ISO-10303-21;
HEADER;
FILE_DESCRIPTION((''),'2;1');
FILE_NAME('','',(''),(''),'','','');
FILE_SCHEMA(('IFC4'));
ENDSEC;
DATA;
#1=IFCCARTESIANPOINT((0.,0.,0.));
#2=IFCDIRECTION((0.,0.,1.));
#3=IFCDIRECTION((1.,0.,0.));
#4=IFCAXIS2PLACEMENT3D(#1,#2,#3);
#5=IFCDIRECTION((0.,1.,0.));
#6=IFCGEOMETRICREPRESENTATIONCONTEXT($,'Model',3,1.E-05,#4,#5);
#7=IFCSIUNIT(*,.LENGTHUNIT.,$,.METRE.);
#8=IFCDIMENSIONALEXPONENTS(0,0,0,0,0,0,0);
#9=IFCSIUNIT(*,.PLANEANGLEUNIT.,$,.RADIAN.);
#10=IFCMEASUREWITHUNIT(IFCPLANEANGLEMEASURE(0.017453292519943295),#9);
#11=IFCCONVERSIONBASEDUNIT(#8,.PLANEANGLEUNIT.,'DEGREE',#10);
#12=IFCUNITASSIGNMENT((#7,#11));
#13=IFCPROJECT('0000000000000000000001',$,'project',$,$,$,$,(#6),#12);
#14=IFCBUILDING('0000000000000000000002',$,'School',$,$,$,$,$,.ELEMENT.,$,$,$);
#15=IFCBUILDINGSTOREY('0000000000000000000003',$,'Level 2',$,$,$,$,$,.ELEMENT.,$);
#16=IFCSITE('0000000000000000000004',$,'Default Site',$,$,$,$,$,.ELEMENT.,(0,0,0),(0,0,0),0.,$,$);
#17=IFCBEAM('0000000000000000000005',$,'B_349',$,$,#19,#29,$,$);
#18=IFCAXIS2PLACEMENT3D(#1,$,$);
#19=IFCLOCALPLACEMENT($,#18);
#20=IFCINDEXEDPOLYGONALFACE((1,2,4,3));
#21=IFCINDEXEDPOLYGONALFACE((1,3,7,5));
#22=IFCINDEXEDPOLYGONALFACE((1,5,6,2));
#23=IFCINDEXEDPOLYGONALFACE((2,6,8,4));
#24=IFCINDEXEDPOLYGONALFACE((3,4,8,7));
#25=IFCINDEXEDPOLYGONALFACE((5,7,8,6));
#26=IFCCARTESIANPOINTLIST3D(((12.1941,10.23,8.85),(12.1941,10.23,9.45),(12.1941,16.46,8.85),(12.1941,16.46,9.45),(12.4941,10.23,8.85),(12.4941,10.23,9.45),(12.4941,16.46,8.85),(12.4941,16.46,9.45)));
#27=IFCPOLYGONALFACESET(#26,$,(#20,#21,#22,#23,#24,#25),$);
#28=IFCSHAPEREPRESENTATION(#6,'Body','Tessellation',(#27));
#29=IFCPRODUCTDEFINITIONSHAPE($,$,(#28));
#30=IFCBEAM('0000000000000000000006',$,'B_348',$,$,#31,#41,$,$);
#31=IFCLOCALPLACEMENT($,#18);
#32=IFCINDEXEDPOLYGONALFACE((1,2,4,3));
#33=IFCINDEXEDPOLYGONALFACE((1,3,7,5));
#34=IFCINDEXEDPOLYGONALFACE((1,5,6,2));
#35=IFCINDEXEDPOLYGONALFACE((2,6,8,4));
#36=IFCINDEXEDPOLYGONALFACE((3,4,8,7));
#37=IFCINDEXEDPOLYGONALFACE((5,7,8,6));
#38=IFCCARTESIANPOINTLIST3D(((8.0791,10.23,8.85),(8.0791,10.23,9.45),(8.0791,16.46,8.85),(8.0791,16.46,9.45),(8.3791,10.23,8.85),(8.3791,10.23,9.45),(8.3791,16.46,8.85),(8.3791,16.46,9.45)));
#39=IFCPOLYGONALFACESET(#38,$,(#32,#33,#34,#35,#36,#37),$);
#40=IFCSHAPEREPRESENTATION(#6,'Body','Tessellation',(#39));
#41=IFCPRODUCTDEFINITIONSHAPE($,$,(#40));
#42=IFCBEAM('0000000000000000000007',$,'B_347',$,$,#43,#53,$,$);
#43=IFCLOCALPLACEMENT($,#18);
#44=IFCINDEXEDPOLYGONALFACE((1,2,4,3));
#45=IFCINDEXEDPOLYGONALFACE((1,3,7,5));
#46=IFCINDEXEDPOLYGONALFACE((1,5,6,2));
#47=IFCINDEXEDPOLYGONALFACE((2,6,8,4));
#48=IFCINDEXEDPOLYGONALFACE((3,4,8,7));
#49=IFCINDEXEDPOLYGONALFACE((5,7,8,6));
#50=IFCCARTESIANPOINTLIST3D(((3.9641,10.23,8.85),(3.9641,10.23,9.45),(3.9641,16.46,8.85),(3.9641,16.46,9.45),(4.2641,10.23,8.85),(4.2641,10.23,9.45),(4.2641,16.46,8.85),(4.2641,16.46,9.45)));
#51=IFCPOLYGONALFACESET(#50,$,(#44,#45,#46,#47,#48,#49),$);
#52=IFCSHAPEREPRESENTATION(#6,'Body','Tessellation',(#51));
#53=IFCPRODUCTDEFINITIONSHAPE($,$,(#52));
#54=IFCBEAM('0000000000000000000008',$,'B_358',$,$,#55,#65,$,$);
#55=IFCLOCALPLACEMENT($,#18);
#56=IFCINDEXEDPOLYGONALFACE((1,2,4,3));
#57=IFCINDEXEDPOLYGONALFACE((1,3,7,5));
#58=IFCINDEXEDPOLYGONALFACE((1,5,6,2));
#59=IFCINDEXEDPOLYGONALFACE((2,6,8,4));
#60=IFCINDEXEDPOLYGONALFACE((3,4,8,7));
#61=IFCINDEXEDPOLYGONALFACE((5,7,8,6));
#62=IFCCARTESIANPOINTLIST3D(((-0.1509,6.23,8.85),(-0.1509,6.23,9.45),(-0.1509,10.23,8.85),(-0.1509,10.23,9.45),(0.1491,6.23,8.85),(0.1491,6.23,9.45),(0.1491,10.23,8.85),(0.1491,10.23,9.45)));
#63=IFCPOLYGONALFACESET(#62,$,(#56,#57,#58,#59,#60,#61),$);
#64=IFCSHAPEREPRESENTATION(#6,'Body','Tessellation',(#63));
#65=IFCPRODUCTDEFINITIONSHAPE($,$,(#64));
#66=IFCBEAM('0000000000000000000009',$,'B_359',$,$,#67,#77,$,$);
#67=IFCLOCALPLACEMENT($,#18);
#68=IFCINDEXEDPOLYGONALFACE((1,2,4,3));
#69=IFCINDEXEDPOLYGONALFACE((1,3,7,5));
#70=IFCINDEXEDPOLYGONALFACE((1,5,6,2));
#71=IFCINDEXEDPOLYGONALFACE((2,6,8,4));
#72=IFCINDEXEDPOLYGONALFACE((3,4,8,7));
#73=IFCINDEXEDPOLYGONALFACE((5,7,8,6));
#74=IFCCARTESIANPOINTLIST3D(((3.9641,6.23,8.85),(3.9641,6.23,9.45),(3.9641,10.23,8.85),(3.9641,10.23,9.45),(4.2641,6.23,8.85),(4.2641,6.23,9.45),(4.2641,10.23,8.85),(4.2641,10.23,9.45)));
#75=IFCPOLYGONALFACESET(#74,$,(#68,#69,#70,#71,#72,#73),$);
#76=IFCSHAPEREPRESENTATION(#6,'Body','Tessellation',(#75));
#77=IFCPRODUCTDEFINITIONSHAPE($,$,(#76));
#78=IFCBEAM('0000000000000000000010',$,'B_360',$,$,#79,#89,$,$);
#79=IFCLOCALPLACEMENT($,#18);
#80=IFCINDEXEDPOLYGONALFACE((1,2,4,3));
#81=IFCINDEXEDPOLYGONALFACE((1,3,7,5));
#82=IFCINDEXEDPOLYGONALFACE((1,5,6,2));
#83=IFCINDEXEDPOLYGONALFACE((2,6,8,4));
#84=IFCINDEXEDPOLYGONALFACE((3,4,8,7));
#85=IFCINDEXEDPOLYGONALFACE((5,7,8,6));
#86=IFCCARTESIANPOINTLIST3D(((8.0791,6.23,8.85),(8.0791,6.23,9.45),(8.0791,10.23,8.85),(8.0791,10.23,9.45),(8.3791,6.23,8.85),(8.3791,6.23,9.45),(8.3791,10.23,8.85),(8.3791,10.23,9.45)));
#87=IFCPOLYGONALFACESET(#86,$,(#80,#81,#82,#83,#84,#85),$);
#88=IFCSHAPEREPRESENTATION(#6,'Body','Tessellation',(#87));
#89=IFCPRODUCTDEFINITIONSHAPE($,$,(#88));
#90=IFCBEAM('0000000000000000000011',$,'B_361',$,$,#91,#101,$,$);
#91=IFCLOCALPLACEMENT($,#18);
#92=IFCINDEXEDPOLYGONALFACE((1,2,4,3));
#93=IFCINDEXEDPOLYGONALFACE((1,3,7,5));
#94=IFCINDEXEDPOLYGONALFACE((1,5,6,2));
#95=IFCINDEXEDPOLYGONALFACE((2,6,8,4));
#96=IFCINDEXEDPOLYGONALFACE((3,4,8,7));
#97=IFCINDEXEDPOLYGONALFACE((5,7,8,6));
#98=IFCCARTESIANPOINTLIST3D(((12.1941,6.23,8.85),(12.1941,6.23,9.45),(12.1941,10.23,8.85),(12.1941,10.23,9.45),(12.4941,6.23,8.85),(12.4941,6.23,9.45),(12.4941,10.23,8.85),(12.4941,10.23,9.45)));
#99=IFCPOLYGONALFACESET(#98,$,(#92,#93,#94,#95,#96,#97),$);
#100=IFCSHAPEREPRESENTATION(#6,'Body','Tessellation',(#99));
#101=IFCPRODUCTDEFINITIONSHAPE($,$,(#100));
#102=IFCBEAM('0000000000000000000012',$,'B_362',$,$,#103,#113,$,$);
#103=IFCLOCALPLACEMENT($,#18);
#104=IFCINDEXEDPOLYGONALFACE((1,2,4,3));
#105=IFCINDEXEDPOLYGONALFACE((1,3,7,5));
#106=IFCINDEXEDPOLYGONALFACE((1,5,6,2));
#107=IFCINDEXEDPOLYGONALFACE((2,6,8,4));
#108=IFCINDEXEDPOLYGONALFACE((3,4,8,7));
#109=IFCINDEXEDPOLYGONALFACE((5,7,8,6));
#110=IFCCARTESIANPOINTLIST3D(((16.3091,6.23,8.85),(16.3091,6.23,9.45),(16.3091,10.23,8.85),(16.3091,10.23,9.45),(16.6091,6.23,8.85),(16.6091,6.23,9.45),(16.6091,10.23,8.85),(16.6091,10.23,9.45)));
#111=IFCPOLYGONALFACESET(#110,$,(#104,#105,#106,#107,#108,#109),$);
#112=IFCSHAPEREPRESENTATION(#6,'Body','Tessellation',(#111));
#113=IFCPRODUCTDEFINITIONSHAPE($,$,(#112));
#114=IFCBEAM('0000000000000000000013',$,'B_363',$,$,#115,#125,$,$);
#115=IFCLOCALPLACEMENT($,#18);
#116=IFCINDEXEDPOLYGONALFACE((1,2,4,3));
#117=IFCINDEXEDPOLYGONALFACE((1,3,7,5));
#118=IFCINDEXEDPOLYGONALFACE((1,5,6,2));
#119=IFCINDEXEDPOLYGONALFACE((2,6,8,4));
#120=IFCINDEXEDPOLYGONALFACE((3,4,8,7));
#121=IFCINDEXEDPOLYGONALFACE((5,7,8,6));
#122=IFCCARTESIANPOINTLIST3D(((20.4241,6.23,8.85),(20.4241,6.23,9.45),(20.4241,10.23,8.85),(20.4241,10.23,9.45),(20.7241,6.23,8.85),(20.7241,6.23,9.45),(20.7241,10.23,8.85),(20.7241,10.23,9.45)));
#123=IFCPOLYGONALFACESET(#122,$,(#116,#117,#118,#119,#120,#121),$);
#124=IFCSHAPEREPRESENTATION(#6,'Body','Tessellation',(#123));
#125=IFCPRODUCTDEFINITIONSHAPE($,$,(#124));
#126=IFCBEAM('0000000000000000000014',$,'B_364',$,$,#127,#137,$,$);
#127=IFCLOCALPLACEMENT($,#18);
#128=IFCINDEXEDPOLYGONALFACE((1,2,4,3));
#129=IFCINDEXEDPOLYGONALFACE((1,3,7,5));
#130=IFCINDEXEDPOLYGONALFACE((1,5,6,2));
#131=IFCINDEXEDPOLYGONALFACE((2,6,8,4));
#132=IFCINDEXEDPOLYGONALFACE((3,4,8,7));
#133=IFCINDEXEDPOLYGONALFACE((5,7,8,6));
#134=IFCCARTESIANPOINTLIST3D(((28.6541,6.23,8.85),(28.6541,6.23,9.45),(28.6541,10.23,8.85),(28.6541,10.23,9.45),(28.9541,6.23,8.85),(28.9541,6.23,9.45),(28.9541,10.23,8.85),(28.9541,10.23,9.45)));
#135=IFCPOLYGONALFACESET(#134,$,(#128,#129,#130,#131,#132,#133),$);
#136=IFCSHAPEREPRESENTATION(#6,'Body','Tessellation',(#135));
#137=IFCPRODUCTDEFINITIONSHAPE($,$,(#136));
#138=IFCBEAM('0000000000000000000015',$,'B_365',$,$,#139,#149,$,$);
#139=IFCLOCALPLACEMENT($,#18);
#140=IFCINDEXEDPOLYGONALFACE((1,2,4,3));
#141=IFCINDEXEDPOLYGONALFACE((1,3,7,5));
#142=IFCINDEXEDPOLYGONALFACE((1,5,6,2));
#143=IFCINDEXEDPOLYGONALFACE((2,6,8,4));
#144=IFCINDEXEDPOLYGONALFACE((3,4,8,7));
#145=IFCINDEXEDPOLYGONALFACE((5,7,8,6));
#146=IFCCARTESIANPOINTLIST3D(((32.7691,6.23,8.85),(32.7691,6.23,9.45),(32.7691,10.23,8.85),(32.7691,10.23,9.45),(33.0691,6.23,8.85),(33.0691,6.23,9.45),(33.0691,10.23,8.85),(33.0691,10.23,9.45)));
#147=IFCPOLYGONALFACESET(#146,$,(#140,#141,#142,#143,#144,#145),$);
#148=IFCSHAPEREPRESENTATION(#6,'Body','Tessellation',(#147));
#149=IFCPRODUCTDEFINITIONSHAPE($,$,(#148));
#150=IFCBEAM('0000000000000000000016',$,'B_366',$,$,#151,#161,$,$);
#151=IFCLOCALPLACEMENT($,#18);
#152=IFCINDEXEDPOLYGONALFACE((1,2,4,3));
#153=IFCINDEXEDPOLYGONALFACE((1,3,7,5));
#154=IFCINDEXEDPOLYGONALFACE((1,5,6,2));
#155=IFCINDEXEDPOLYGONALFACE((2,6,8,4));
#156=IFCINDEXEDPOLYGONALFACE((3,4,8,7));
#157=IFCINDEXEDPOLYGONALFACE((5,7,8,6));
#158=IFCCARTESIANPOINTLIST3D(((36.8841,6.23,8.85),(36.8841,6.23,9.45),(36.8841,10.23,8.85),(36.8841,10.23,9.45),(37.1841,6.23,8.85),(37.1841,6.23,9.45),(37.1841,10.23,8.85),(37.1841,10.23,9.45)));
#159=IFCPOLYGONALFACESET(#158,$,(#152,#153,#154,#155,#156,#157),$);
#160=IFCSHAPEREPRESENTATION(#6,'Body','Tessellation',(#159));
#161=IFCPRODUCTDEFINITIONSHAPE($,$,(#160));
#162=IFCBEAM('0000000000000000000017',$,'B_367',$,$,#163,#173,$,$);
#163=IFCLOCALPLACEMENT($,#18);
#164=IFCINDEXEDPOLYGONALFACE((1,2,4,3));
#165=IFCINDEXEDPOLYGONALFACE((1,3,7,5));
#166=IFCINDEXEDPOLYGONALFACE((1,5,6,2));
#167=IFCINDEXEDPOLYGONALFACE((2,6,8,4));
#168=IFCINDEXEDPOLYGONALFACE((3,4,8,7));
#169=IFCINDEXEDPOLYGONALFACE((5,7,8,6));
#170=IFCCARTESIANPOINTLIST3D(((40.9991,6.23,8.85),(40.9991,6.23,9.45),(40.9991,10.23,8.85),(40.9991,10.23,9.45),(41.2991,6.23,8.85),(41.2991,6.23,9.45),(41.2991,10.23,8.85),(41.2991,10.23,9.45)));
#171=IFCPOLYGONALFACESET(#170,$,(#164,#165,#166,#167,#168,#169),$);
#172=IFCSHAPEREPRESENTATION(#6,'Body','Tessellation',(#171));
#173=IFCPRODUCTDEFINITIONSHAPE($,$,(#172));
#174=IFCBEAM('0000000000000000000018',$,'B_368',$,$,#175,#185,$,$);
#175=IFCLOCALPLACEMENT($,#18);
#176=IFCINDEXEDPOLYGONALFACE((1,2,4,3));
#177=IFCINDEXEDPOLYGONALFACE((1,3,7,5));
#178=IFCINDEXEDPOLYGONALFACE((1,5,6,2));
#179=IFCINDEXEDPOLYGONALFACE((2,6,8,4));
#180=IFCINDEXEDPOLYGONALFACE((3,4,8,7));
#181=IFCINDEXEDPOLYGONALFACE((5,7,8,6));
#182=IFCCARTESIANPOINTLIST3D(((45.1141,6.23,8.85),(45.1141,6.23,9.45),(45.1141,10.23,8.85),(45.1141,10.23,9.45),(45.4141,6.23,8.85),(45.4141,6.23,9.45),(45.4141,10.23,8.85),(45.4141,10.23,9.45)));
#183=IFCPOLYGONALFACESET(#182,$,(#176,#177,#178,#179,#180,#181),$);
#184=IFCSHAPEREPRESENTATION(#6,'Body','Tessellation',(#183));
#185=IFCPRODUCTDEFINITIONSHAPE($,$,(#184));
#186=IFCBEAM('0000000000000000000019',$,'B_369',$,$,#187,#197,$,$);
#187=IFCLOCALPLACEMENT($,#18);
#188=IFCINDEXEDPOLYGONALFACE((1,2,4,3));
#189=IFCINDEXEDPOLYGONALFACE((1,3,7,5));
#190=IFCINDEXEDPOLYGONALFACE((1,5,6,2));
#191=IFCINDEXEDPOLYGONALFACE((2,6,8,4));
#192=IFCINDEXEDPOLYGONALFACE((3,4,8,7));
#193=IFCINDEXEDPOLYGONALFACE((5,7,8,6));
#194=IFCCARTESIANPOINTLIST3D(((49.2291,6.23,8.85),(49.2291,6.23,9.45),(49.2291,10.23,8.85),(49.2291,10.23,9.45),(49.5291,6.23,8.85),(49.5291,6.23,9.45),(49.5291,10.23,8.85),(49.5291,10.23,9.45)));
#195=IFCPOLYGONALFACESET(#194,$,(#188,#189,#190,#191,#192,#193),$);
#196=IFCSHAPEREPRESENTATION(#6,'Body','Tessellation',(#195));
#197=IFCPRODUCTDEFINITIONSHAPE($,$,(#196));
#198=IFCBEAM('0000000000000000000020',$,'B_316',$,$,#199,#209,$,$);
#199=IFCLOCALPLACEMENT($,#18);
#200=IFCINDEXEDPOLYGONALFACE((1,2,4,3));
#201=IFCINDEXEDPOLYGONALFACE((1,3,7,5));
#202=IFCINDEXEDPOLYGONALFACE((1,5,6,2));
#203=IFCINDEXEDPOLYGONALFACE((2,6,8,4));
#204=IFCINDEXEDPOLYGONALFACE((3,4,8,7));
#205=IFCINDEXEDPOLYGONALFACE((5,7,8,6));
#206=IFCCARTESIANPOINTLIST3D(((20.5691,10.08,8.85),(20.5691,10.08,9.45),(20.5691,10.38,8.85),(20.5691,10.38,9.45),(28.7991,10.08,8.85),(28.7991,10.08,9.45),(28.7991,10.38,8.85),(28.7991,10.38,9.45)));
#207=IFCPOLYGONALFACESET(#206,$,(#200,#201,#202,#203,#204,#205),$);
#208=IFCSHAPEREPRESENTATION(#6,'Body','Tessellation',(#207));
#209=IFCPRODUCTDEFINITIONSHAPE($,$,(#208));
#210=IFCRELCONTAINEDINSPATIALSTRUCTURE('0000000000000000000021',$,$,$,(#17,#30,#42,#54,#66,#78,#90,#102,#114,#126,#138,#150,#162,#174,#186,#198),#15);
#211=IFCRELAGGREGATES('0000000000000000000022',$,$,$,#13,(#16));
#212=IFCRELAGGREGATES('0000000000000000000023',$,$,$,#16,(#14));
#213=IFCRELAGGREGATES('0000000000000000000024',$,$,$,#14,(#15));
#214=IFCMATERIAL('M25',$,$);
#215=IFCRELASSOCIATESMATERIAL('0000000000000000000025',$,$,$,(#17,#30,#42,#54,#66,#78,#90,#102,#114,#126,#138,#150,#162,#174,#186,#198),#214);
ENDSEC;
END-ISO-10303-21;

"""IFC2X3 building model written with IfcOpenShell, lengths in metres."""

from ifc_helpers import new_model, entity, si_unit, converted_unit, direction, frame, frame_2d, origin_with_axes, place, context, project, spatial, rectangle, extrude, material, element, save


model = new_model("IFC2X3")

# Units and contexts
model_context = context("Model", 3, precision=1e-05, world=origin_with_axes(), true_north=direction((0.0, 1.0, 0.0)))
ifc_project = project(units=[si_unit("LENGTHUNIT", "METRE"), converted_unit("PLANEANGLEUNIT", "DEGREE", entity("IfcPlaneAngleMeasure", 0.017453292519943295), si_unit("PLANEANGLEUNIT", "RADIAN"), dimensions=[0, 0, 0, 0, 0, 0, 0])], contexts=[model_context])

# Site, building, storey
site = spatial("IfcSite", under=ifc_project, Name="Default Site", CompositionType="ELEMENT", RefLatitude=(0, 0, 0), RefLongitude=(0, 0, 0), RefElevation=0.0)
building = spatial("IfcBuilding", under=site, Name="School", CompositionType="ELEMENT")
storey = spatial("IfcBuildingStorey", under=building, Name="Level 2", CompositionType="ELEMENT")

# Shared definitions
ifc_material = material(Name="M25")
placement = place(None, origin_with_axes())

# Beams
element("IfcBeam", 1, at=placement, inside=storey, material=ifc_material, Name="B_349", context=model_context, shape_type="SweptSolid", body=[
    extrude(rectangle(XDim=0.3, YDim=0.6, at=frame_2d((0.0, 0.0), x_axis=(0.0, 1.0, 0.0))), frame((12.3441, 10.23, 9.15), z_axis=(0.0, 1.0, 0.0), x_axis=(0.0, 0.0, -1.0)), (0.0, 0.0, 1.0), 6.23),
])
element("IfcBeam", 2, at=placement, inside=storey, material=ifc_material, Name="B_348", context=model_context, shape_type="SweptSolid", body=[
    extrude(rectangle(XDim=0.3, YDim=0.6, at=frame_2d((0.0, 0.0), x_axis=(0.0, 1.0, 0.0))), frame((8.2291, 10.23, 9.15), z_axis=(0.0, 1.0, 0.0), x_axis=(0.0, 0.0, -1.0)), (0.0, 0.0, 1.0), 6.23),
])
element("IfcBeam", 3, at=placement, inside=storey, material=ifc_material, Name="B_347", context=model_context, shape_type="SweptSolid", body=[
    extrude(rectangle(XDim=0.3, YDim=0.6, at=frame_2d((0.0, 0.0), x_axis=(0.0, 1.0, 0.0))), frame((4.1141, 10.23, 9.15), z_axis=(0.0, 1.0, 0.0), x_axis=(0.0, 0.0, -1.0)), (0.0, 0.0, 1.0), 6.23),
])
element("IfcBeam", 4, at=placement, inside=storey, material=ifc_material, Name="B_358", context=model_context, shape_type="SweptSolid", body=[
    extrude(rectangle(XDim=0.3, YDim=0.6, at=frame_2d((0.0, 0.0), x_axis=(0.0, 1.0, 0.0))), frame((-0.0009, 6.23, 9.15), z_axis=(0.0, 1.0, 0.0), x_axis=(0.0, 0.0, -1.0)), (0.0, 0.0, 1.0), 4.0),
])
element("IfcBeam", 5, at=placement, inside=storey, material=ifc_material, Name="B_359", context=model_context, shape_type="SweptSolid", body=[
    extrude(rectangle(XDim=0.3, YDim=0.6, at=frame_2d((0.0, 0.0), x_axis=(0.0, 1.0, 0.0))), frame((4.1141, 6.23, 9.15), z_axis=(0.0, 1.0, 0.0), x_axis=(0.0, 0.0, -1.0)), (0.0, 0.0, 1.0), 4.0),
])
element("IfcBeam", 6, at=placement, inside=storey, material=ifc_material, Name="B_360", context=model_context, shape_type="SweptSolid", body=[
    extrude(rectangle(XDim=0.3, YDim=0.6, at=frame_2d((0.0, 0.0), x_axis=(0.0, 1.0, 0.0))), frame((8.2291, 6.23, 9.15), z_axis=(0.0, 1.0, 0.0), x_axis=(0.0, 0.0, -1.0)), (0.0, 0.0, 1.0), 4.0),
])
element("IfcBeam", 7, at=placement, inside=storey, material=ifc_material, Name="B_361", context=model_context, shape_type="SweptSolid", body=[
    extrude(rectangle(XDim=0.3, YDim=0.6, at=frame_2d((0.0, 0.0), x_axis=(0.0, 1.0, 0.0))), frame((12.3441, 6.23, 9.15), z_axis=(0.0, 1.0, 0.0), x_axis=(0.0, 0.0, -1.0)), (0.0, 0.0, 1.0), 4.0),
])
element("IfcBeam", 8, at=placement, inside=storey, material=ifc_material, Name="B_362", context=model_context, shape_type="SweptSolid", body=[
    extrude(rectangle(XDim=0.3, YDim=0.6, at=frame_2d((0.0, 0.0), x_axis=(0.0, 1.0, 0.0))), frame((16.4591, 6.23, 9.15), z_axis=(0.0, 1.0, 0.0), x_axis=(0.0, 0.0, -1.0)), (0.0, 0.0, 1.0), 4.0),
])
element("IfcBeam", 9, at=placement, inside=storey, material=ifc_material, Name="B_363", context=model_context, shape_type="SweptSolid", body=[
    extrude(rectangle(XDim=0.3, YDim=0.6, at=frame_2d((0.0, 0.0), x_axis=(0.0, 1.0, 0.0))), frame((20.5741, 6.23, 9.15), z_axis=(0.0, 1.0, 0.0), x_axis=(0.0, 0.0, -1.0)), (0.0, 0.0, 1.0), 4.0),
])
element("IfcBeam", 10, at=placement, inside=storey, material=ifc_material, Name="B_364", context=model_context, shape_type="SweptSolid", body=[
    extrude(rectangle(XDim=0.3, YDim=0.6, at=frame_2d((0.0, 0.0), x_axis=(0.0, 1.0, 0.0))), frame((28.8041, 6.23, 9.15), z_axis=(0.0, 1.0, 0.0), x_axis=(0.0, 0.0, -1.0)), (0.0, 0.0, 1.0), 4.0),
])
element("IfcBeam", 11, at=placement, inside=storey, material=ifc_material, Name="B_365", context=model_context, shape_type="SweptSolid", body=[
    extrude(rectangle(XDim=0.3, YDim=0.6, at=frame_2d((0.0, 0.0), x_axis=(0.0, 1.0, 0.0))), frame((32.9191, 6.23, 9.15), z_axis=(0.0, 1.0, 0.0), x_axis=(0.0, 0.0, -1.0)), (0.0, 0.0, 1.0), 4.0),
])
element("IfcBeam", 12, at=placement, inside=storey, material=ifc_material, Name="B_366", context=model_context, shape_type="SweptSolid", body=[
    extrude(rectangle(XDim=0.3, YDim=0.6, at=frame_2d((0.0, 0.0), x_axis=(0.0, 1.0, 0.0))), frame((37.0341, 6.23, 9.15), z_axis=(0.0, 1.0, 0.0), x_axis=(0.0, 0.0, -1.0)), (0.0, 0.0, 1.0), 4.0),
])
element("IfcBeam", 13, at=placement, inside=storey, material=ifc_material, Name="B_367", context=model_context, shape_type="SweptSolid", body=[
    extrude(rectangle(XDim=0.3, YDim=0.6, at=frame_2d((0.0, 0.0), x_axis=(0.0, 1.0, 0.0))), frame((41.1491, 6.23, 9.15), z_axis=(0.0, 1.0, 0.0), x_axis=(0.0, 0.0, -1.0)), (0.0, 0.0, 1.0), 4.0),
])
element("IfcBeam", 14, at=placement, inside=storey, material=ifc_material, Name="B_368", context=model_context, shape_type="SweptSolid", body=[
    extrude(rectangle(XDim=0.3, YDim=0.6, at=frame_2d((0.0, 0.0), x_axis=(0.0, 1.0, 0.0))), frame((45.2641, 6.23, 9.15), z_axis=(0.0, 1.0, 0.0), x_axis=(0.0, 0.0, -1.0)), (0.0, 0.0, 1.0), 4.0),
])
element("IfcBeam", 15, at=placement, inside=storey, material=ifc_material, Name="B_369", context=model_context, shape_type="SweptSolid", body=[
    extrude(rectangle(XDim=0.3, YDim=0.6, at=frame_2d((0.0, 0.0), x_axis=(0.0, 1.0, 0.0))), frame((49.3791, 6.23, 9.15), z_axis=(0.0, 1.0, 0.0), x_axis=(0.0, 0.0, -1.0)), (0.0, 0.0, 1.0), 4.0),
])
element("IfcBeam", 16, at=placement, inside=storey, material=ifc_material, Name="B_316", context=model_context, shape_type="SweptSolid", body=[
    extrude(rectangle(XDim=0.3, YDim=0.6, at=frame_2d((0.0, 0.0), x_axis=(0.0, 1.0, 0.0))), frame((20.5691, 10.23, 9.15), z_axis=(1.0, 0.0, 0.0), x_axis=(0.0, 0.0, -1.0)), (0.0, 0.0, 1.0), 8.23),
])

save(model, "model.ifc")
